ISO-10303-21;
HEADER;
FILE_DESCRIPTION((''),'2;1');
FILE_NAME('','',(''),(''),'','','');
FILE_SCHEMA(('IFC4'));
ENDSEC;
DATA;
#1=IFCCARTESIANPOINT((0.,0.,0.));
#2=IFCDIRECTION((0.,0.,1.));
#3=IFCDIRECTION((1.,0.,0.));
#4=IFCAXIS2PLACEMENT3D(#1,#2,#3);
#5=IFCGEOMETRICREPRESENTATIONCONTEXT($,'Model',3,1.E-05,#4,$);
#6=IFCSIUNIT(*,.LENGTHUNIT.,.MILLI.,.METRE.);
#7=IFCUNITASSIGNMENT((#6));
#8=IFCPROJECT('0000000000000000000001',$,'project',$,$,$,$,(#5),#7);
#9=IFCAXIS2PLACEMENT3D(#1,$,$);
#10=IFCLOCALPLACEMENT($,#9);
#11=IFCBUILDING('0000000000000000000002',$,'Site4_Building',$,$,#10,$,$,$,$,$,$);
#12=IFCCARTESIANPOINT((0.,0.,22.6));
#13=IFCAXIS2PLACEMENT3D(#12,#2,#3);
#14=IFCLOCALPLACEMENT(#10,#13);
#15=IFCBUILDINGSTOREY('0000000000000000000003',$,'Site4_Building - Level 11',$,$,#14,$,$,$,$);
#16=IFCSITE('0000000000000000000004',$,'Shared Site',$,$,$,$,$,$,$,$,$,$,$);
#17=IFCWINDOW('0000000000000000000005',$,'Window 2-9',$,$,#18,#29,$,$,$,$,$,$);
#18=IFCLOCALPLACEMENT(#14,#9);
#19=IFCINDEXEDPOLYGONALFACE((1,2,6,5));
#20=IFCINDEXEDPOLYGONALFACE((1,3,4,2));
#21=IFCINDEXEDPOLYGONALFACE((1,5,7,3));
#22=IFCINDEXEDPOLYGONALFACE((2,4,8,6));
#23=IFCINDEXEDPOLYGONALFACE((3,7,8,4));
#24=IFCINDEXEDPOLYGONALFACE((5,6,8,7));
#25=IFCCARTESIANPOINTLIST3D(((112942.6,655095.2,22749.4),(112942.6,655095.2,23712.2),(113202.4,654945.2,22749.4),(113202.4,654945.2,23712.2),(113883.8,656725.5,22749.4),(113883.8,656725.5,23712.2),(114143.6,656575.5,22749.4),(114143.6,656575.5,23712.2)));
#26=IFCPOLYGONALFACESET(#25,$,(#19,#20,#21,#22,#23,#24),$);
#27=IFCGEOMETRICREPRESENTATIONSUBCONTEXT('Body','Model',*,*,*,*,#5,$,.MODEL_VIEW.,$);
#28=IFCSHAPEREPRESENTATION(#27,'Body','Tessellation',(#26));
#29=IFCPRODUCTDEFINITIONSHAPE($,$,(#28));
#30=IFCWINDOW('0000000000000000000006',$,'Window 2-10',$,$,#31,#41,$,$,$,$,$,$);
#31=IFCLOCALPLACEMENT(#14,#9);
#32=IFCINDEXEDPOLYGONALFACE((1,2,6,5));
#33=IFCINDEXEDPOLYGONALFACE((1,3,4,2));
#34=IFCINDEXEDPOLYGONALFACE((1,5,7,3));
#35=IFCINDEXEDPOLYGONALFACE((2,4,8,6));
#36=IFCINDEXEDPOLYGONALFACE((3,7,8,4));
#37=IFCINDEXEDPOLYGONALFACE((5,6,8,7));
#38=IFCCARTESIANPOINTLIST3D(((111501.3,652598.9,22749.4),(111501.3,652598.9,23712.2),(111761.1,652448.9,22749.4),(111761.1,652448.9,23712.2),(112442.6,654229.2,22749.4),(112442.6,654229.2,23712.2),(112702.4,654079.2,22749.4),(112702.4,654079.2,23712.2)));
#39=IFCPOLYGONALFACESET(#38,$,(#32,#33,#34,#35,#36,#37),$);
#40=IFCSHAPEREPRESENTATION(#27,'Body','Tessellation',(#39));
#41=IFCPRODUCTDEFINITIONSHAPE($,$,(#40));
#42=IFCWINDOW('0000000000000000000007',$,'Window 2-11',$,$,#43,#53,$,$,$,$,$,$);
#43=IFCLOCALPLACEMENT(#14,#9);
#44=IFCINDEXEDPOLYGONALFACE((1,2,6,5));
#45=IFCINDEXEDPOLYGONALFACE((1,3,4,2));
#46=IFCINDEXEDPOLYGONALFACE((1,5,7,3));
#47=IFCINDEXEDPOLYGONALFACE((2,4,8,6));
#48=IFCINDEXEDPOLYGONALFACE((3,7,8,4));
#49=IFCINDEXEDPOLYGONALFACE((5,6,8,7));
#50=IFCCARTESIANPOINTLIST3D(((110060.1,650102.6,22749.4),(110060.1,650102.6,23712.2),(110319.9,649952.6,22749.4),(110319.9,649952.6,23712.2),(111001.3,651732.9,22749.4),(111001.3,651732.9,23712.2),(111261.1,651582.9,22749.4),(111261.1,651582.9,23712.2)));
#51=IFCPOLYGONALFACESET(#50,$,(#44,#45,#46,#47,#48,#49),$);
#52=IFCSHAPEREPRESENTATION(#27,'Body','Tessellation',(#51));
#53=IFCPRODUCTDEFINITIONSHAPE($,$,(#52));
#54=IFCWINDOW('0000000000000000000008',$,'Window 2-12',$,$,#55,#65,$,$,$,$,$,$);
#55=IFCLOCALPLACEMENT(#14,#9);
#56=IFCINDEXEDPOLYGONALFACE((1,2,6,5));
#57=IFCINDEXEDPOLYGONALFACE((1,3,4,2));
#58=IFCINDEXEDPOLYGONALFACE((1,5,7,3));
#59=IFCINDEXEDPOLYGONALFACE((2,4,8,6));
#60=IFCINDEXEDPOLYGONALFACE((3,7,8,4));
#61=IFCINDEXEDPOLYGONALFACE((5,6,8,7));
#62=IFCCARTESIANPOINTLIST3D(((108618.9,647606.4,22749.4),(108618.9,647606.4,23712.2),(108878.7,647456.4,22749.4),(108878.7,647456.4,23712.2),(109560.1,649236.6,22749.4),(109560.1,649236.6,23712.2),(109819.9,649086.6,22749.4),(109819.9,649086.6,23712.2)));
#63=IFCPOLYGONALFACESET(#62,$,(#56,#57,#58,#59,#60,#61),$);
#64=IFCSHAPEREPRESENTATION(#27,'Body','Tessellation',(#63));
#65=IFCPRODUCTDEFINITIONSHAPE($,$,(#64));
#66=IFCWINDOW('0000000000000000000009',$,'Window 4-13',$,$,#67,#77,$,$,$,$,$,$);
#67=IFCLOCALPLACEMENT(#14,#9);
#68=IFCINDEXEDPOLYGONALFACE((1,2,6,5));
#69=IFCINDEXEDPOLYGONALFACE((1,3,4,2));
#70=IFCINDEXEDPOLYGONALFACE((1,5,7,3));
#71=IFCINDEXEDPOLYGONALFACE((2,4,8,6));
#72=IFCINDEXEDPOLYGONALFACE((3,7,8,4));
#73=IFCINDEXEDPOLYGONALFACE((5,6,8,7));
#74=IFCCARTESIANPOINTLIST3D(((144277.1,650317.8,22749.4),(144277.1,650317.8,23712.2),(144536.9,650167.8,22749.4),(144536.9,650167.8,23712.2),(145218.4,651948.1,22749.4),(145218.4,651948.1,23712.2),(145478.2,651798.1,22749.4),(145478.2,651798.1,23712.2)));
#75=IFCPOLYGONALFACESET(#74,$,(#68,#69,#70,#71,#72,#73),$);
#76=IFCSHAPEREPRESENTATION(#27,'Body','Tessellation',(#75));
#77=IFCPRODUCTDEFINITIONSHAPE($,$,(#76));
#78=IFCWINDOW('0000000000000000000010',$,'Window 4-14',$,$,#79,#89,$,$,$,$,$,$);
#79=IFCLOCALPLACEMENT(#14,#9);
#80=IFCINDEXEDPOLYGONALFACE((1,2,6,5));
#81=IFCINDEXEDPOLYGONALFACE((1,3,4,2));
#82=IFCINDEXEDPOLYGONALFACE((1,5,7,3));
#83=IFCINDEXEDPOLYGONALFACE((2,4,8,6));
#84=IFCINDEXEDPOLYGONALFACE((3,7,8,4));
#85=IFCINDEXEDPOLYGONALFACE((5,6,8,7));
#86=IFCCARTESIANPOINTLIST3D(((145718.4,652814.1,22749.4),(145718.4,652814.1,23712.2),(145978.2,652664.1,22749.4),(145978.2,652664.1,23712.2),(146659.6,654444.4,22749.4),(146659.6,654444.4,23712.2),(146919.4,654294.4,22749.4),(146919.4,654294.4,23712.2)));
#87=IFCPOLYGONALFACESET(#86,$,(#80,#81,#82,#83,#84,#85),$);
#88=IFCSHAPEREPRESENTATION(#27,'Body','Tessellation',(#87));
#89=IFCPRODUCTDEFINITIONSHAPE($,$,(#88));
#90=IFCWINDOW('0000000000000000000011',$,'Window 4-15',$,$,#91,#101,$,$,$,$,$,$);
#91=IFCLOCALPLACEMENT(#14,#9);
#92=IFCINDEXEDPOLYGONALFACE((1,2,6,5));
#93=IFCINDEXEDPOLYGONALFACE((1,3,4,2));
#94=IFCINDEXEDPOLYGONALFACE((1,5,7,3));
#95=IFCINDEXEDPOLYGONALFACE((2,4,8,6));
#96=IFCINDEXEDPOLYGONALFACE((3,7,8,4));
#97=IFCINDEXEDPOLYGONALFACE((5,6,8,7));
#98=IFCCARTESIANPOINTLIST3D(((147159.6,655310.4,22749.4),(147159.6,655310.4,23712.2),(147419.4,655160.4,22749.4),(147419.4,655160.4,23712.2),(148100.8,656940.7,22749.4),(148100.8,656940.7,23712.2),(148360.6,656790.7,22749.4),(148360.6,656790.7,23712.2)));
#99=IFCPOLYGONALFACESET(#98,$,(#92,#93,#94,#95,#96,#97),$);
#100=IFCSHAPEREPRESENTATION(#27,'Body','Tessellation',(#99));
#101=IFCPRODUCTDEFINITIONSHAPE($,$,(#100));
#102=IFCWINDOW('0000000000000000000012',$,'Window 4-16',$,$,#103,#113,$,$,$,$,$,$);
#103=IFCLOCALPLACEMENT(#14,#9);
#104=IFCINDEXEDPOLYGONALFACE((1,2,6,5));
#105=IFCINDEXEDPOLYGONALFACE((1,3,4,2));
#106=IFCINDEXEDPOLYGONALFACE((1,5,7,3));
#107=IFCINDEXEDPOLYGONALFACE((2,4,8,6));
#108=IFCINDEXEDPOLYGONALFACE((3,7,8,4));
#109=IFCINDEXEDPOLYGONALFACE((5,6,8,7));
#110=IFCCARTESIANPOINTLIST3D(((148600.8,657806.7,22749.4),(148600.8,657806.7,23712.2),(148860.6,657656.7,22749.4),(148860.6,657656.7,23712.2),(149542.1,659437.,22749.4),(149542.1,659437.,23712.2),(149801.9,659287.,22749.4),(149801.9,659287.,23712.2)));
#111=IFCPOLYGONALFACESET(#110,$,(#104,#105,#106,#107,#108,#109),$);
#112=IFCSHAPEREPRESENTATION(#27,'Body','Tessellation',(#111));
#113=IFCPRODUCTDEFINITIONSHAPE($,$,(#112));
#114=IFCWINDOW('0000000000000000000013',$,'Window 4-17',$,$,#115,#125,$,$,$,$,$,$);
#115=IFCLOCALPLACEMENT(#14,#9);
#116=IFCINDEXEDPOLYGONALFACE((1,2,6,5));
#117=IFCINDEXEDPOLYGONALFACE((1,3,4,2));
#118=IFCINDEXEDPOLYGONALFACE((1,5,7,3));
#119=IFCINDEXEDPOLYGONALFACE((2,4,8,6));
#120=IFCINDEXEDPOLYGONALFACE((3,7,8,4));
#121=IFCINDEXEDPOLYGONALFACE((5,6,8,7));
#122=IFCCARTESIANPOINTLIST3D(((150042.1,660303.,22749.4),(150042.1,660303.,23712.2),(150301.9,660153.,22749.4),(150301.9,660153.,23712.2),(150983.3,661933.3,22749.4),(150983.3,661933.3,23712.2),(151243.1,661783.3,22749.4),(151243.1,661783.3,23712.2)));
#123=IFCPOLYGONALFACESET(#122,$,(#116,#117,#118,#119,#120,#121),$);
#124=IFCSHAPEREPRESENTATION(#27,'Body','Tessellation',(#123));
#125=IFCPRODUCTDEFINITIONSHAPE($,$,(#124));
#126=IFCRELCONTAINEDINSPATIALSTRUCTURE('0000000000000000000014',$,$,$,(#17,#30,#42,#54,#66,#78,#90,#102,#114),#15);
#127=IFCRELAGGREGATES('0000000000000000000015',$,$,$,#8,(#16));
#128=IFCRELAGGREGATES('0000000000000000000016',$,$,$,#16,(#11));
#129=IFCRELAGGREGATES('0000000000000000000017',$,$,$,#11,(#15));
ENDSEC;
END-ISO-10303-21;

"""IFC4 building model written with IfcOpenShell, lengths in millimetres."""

from ifc_helpers import new_model, si_unit, frame, origin, origin_with_axes, place, context, subcontext, project, spatial, indexed_curve, outline, extrude, element, save


model = new_model("IFC4")

# Units and contexts
model_context = context("Model", 3, precision=1e-05, world=origin_with_axes())
body_context = subcontext(model_context, "Body", "Model", "MODEL_VIEW")
ifc_project = project(units=[si_unit("LENGTHUNIT", "METRE", prefix="MILLI")], contexts=[model_context])

# Site, building, storey
site = spatial("IfcSite", under=ifc_project, Name="Shared Site")
building_placement = place(None, origin())
building = spatial("IfcBuilding", under=site, at=building_placement, Name="Site4_Building")
storey_placement = place(building_placement, frame((0.0, 0.0, 22.6), z_axis=(0.0, 0.0, 1.0), x_axis=(1.0, 0.0, 0.0)))
storey = spatial("IfcBuildingStorey", under=building, at=storey_placement, Name="Site4_Building - Level 11")

# Windows
for number, where, z_axis, x_axis, name in (
    (1, (113883.8, 656725.5, 22749.4), (0.0, 0.0, 1.0), (-0.5, -0.866025, 0.0), "Window 2-9"),
    (2, (112442.6, 654229.2, 22749.4), (0.0, 0.0, 1.0), (-0.5, -0.866025, 0.0), "Window 2-10"),
    (3, (111001.3, 651732.9, 22749.4), (0.0, 0.0, 1.0), (-0.5, -0.866025, 0.0), "Window 2-11"),
    (4, (109560.1, 649236.6, 22749.4), (0.0, 0.0, 1.0), (-0.5, -0.866025, 0.0), "Window 2-12"),
    (5, (144536.9, 650167.8, 22749.4), (0.0, 0.0, 1.0), (0.5, 0.866025, 0.0), "Window 4-13"),
    (6, (145978.2, 652664.1, 22749.4), (0.0, 0.0, 1.0), (0.5, 0.866025, 0.0), "Window 4-14"),
    (7, (147419.4, 655160.4, 22749.4), (0.0, 0.0, 1.0), (0.5, 0.866025, 0.0), "Window 4-15"),
    (8, (148860.6, 657656.7, 22749.4), (0.0, 0.0, 1.0), (0.5, 0.866025, 0.0), "Window 4-16"),
    (9, (150301.9, 660153.0, 22749.4), (0.0, 0.0, 1.0), (0.5, 0.866025, 0.0), "Window 4-17"),
):
    element("IfcWindow", number, at=place(storey_placement, frame(where, z_axis=z_axis, x_axis=x_axis)), inside=storey, Name=name, context=body_context, shape_type="SweptSolid", body=[
        extrude(outline(indexed_curve([(0.0, 0.0), (0.0, 300.0), (1882.5, 300.0), (1882.5, 0.0), (0.0, 0.0)], self_intersect=False)), origin_with_axes(), (0.0, 0.0, 1.0), 962.8),
    ])

save(model, "model.ifc")
